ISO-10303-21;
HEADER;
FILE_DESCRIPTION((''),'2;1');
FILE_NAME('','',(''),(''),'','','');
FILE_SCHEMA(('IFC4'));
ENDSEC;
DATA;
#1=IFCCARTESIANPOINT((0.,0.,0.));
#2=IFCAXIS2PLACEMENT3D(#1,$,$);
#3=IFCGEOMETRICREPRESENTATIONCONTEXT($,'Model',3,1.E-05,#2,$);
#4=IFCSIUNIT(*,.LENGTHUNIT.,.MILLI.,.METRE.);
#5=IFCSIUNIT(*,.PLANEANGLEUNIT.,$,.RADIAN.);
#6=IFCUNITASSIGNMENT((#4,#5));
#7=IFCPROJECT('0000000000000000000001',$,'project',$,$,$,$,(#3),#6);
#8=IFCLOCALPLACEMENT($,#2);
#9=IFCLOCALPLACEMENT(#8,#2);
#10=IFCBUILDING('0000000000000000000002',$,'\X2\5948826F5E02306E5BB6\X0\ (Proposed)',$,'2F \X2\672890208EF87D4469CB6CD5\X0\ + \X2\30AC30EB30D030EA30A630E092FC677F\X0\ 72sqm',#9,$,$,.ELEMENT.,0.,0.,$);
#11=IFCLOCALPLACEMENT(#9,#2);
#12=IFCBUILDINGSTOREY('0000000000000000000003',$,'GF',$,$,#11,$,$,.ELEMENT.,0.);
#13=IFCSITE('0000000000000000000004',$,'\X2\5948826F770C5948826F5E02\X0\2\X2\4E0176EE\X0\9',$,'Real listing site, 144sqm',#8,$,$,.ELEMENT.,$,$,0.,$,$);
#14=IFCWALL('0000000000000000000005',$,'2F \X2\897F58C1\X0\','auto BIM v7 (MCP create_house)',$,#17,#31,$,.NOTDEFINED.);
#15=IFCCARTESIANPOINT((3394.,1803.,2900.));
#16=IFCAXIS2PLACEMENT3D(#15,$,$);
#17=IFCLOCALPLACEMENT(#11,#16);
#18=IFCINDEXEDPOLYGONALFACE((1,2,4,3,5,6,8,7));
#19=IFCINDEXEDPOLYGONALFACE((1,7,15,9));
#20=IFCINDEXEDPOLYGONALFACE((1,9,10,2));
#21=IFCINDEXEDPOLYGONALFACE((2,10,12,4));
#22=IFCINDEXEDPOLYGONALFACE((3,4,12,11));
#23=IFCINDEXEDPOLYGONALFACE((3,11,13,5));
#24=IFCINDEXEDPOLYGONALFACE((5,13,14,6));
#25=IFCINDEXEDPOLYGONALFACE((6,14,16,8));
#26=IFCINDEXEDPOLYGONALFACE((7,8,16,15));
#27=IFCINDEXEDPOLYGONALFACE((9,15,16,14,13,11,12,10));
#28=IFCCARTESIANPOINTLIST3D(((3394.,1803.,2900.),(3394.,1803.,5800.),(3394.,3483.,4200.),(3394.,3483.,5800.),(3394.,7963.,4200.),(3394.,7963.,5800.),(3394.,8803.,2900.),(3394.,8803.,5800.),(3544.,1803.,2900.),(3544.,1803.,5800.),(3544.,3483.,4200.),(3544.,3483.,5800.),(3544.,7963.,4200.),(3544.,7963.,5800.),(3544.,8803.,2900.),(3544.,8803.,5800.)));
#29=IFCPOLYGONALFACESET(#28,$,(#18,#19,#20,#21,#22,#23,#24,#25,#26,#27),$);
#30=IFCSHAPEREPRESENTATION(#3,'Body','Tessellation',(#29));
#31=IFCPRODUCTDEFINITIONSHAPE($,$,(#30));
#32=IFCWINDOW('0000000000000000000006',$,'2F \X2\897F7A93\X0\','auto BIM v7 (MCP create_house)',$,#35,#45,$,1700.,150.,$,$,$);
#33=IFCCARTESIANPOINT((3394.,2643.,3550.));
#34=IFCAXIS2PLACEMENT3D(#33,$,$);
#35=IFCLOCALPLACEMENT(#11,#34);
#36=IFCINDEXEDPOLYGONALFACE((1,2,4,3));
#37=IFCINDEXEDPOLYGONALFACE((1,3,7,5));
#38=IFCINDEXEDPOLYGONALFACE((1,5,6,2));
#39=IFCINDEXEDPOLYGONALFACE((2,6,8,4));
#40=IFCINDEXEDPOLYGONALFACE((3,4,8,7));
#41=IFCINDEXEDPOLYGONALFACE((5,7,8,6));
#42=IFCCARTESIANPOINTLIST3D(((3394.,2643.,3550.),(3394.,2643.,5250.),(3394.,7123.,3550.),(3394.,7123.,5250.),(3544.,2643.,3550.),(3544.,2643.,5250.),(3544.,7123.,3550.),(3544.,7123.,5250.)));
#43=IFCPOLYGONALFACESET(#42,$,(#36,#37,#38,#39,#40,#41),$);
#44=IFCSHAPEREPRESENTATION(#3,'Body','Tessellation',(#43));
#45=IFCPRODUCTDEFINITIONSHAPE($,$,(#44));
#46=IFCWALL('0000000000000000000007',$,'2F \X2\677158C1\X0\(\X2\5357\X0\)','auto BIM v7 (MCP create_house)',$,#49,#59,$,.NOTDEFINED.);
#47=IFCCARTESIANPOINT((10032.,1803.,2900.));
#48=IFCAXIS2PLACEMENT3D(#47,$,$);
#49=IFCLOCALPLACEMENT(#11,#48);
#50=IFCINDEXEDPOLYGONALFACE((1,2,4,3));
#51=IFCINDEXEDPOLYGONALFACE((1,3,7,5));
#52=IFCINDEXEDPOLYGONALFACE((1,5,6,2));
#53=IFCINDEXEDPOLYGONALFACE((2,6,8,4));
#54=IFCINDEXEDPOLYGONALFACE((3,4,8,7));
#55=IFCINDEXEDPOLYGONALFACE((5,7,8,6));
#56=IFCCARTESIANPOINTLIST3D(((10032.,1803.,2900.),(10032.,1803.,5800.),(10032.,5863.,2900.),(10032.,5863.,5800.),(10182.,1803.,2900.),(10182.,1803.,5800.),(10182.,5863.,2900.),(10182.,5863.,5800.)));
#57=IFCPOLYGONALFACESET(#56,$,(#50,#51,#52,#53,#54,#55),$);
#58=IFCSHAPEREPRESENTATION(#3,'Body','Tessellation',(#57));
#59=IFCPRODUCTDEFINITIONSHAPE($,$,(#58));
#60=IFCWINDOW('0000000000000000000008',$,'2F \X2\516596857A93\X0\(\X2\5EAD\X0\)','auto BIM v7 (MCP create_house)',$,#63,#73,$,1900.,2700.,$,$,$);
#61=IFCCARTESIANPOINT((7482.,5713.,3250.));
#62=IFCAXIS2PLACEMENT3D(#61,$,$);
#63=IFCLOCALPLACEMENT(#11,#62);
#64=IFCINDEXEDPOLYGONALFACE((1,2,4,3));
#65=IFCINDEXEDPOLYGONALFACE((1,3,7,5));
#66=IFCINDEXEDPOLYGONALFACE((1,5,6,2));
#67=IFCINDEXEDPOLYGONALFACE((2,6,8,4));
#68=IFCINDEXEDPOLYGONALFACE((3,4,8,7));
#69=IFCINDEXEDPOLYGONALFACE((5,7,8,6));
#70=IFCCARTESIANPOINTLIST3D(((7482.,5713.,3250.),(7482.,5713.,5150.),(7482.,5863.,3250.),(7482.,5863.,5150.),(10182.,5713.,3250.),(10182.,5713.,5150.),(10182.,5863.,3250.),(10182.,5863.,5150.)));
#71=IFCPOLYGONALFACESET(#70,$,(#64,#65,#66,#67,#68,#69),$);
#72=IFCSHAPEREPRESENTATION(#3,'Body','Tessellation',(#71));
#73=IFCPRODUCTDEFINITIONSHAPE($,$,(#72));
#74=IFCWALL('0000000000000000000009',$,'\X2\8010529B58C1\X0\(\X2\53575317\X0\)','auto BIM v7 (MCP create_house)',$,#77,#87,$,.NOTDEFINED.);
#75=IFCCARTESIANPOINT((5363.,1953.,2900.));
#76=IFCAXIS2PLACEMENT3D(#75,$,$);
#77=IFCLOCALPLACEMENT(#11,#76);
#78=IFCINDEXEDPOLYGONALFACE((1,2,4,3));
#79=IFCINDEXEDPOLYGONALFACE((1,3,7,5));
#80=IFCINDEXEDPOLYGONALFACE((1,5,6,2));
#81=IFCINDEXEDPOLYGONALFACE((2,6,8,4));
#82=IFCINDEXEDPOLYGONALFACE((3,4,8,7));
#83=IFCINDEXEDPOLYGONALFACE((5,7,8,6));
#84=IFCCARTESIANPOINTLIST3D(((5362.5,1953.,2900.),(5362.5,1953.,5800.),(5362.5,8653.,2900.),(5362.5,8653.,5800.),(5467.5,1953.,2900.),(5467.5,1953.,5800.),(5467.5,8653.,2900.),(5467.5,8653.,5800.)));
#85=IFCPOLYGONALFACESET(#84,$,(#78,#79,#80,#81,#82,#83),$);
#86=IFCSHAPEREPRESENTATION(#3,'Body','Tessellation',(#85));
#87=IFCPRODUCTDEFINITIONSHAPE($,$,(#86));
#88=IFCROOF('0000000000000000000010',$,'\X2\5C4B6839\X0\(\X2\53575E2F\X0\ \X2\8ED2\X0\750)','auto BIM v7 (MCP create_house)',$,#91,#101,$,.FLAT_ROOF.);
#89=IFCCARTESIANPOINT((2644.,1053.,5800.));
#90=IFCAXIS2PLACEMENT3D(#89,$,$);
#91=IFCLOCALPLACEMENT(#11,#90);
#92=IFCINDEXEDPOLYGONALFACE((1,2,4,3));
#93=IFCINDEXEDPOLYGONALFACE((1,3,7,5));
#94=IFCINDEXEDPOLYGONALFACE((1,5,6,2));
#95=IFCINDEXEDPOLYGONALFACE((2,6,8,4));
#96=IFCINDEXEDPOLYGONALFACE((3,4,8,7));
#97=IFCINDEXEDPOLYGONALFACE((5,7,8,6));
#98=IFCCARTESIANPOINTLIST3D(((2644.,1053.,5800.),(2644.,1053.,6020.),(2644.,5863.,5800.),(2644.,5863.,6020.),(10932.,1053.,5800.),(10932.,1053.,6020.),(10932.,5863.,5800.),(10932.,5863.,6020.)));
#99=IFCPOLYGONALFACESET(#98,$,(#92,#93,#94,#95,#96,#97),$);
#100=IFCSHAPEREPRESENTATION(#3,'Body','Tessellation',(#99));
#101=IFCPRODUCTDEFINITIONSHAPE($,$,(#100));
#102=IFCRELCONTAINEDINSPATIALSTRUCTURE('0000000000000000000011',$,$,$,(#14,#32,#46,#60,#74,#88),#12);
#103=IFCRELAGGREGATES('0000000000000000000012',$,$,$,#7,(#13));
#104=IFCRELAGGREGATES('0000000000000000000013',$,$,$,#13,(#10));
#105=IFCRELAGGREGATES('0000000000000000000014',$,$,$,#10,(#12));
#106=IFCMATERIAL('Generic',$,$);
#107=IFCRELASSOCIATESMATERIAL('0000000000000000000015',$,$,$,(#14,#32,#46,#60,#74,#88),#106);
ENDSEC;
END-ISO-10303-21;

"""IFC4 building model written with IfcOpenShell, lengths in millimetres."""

from ifc_helpers import new_model, si_unit, frame, frame_2d, origin, place, context, project, spatial, rectangle, extrude, material, element, fill, save


model = new_model("IFC4")

# Units and contexts
model_context = context("Model", 3, precision=1e-05, world=origin())
ifc_project = project(units=[si_unit("LENGTHUNIT", "METRE", prefix="MILLI"), si_unit("PLANEANGLEUNIT", "RADIAN")], contexts=[model_context])

# Site, building, storey
site_placement = place(None, origin())
site = spatial("IfcSite", under=ifc_project, at=site_placement, Name="奈良県奈良市2丁目9", ObjectType="Real listing site, 144sqm", CompositionType="ELEMENT", RefElevation=0.0)
building_placement = place(site_placement, origin())
building = spatial("IfcBuilding", under=site, at=building_placement, Name="奈良市の家 (Proposed)", ObjectType="2F 木造軸組構法 + ガルバリウム鋼板 72sqm", CompositionType="ELEMENT", ElevationOfRefHeight=0.0, ElevationOfTerrain=0.0)
storey_placement = place(building_placement, origin())
storey = spatial("IfcBuildingStorey", under=building, at=storey_placement, Name="GF", CompositionType="ELEMENT", Elevation=0.0)

# Shared definitions
ifc_material = material(Name="Generic")

# Walls, openings, windows
wall_1_placement = place(storey_placement, frame((3394.0, 1803.0, 2900.0)))
wall_1 = element("IfcWall", 1, at=wall_1_placement, inside=storey, material=ifc_material, Name="2F 西壁", Description="auto BIM v7 (MCP create_house)", PredefinedType="NOTDEFINED", context=model_context, shape_type="SweptSolid", body=[
    extrude(rectangle(XDim=150.0, YDim=7000.0, at=frame_2d((75.0, 3500.0))), frame((3394.0, 1803.0, 2900.0)), (0.0, 0.0, 1.0), 2900.0),
])
opening_1_placement = place(storey_placement, frame((3394.0, 2643.0, 3550.0)))
opening_1 = element("IfcOpeningElement", 2, at=opening_1_placement, cuts=wall_1, PredefinedType="NOTDEFINED", context=model_context, shape_type="SweptSolid", body=[
    extrude(rectangle(XDim=150.0, YDim=4480.0, at=frame_2d((75.0, 2240.0))), frame((3394.0, 2643.0, 3550.0)), (0.0, 0.0, 1.0), 1700.0),
])
window_1_placement = place(storey_placement, frame((3394.0, 2643.0, 3550.0)))
window_1 = element("IfcWindow", 3, at=window_1_placement, inside=storey, material=ifc_material, Name="2F 西窓", Description="auto BIM v7 (MCP create_house)", OverallHeight=1700.0, OverallWidth=150.0, context=model_context, shape_type="SweptSolid", body=[
    extrude(rectangle(XDim=150.0, YDim=4480.0, at=frame_2d((75.0, 2240.0))), frame((3394.0, 2643.0, 3550.0)), (0.0, 0.0, 1.0), 1700.0),
])
fill(opening_1, window_1)
wall_2_placement = place(storey_placement, frame((10032.0, 1803.0, 2900.0)))
wall_2 = element("IfcWall", 4, at=wall_2_placement, inside=storey, material=ifc_material, Name="2F 東壁(南)", Description="auto BIM v7 (MCP create_house)", PredefinedType="NOTDEFINED", context=model_context, shape_type="SweptSolid", body=[
    extrude(rectangle(XDim=150.0, YDim=4060.0, at=frame_2d((75.0, 2030.0))), frame((10032.0, 1803.0, 2900.0)), (0.0, 0.0, 1.0), 2900.0),
])
opening_2_placement = place(storey_placement, frame((7482.0, 5713.0, 3250.0)))
opening_2 = element("IfcOpeningElement", 5, at=opening_2_placement, cuts=wall_2, PredefinedType="NOTDEFINED", context=model_context, shape_type="SweptSolid", body=[
    extrude(rectangle(XDim=2700.0, YDim=150.0, at=frame_2d((1350.0, 75.0))), frame((7482.0, 5713.0, 3250.0)), (0.0, 0.0, 1.0), 1900.0),
])
window_2_placement = place(storey_placement, frame((7482.0, 5713.0, 3250.0)))
window_2 = element("IfcWindow", 6, at=window_2_placement, inside=storey, material=ifc_material, Name="2F 入隅窓(庭)", Description="auto BIM v7 (MCP create_house)", OverallHeight=1900.0, OverallWidth=2700.0, context=model_context, shape_type="SweptSolid", body=[
    extrude(rectangle(XDim=2700.0, YDim=150.0, at=frame_2d((1350.0, 75.0))), frame((7482.0, 5713.0, 3250.0)), (0.0, 0.0, 1.0), 1900.0),
])
fill(opening_2, window_2)

# Wall
wall_3_placement = place(storey_placement, frame((5363.0, 1953.0, 2900.0)))
element("IfcWall", 7, at=wall_3_placement, inside=storey, material=ifc_material, Name="耐力壁(南北)", Description="auto BIM v7 (MCP create_house)", PredefinedType="NOTDEFINED", context=model_context, shape_type="SweptSolid", body=[
    extrude(rectangle(XDim=105.0, YDim=6700.0, at=frame_2d((52.0, 3350.0))), frame((5363.0, 1953.0, 2900.0)), (0.0, 0.0, 1.0), 2900.0),
])

# Roof
for number, where, name in (
    (8, (2644.0, 1053.0, 5800.0), "屋根(南帯 軒750)"),
):
    element("IfcRoof", number, at=place(storey_placement, frame(where)), inside=storey, material=ifc_material, Name=name, Description="auto BIM v7 (MCP create_house)", PredefinedType="FLAT_ROOF", context=model_context, shape_type="SweptSolid", body=[
        extrude(rectangle(XDim=8288.0, YDim=4810.0, at=frame_2d((4144.0, 2405.0))), frame((2644.0, 1053.0, 5800.0)), (0.0, 0.0, 1.0), 220.0),
    ])

save(model, "model.ifc")
